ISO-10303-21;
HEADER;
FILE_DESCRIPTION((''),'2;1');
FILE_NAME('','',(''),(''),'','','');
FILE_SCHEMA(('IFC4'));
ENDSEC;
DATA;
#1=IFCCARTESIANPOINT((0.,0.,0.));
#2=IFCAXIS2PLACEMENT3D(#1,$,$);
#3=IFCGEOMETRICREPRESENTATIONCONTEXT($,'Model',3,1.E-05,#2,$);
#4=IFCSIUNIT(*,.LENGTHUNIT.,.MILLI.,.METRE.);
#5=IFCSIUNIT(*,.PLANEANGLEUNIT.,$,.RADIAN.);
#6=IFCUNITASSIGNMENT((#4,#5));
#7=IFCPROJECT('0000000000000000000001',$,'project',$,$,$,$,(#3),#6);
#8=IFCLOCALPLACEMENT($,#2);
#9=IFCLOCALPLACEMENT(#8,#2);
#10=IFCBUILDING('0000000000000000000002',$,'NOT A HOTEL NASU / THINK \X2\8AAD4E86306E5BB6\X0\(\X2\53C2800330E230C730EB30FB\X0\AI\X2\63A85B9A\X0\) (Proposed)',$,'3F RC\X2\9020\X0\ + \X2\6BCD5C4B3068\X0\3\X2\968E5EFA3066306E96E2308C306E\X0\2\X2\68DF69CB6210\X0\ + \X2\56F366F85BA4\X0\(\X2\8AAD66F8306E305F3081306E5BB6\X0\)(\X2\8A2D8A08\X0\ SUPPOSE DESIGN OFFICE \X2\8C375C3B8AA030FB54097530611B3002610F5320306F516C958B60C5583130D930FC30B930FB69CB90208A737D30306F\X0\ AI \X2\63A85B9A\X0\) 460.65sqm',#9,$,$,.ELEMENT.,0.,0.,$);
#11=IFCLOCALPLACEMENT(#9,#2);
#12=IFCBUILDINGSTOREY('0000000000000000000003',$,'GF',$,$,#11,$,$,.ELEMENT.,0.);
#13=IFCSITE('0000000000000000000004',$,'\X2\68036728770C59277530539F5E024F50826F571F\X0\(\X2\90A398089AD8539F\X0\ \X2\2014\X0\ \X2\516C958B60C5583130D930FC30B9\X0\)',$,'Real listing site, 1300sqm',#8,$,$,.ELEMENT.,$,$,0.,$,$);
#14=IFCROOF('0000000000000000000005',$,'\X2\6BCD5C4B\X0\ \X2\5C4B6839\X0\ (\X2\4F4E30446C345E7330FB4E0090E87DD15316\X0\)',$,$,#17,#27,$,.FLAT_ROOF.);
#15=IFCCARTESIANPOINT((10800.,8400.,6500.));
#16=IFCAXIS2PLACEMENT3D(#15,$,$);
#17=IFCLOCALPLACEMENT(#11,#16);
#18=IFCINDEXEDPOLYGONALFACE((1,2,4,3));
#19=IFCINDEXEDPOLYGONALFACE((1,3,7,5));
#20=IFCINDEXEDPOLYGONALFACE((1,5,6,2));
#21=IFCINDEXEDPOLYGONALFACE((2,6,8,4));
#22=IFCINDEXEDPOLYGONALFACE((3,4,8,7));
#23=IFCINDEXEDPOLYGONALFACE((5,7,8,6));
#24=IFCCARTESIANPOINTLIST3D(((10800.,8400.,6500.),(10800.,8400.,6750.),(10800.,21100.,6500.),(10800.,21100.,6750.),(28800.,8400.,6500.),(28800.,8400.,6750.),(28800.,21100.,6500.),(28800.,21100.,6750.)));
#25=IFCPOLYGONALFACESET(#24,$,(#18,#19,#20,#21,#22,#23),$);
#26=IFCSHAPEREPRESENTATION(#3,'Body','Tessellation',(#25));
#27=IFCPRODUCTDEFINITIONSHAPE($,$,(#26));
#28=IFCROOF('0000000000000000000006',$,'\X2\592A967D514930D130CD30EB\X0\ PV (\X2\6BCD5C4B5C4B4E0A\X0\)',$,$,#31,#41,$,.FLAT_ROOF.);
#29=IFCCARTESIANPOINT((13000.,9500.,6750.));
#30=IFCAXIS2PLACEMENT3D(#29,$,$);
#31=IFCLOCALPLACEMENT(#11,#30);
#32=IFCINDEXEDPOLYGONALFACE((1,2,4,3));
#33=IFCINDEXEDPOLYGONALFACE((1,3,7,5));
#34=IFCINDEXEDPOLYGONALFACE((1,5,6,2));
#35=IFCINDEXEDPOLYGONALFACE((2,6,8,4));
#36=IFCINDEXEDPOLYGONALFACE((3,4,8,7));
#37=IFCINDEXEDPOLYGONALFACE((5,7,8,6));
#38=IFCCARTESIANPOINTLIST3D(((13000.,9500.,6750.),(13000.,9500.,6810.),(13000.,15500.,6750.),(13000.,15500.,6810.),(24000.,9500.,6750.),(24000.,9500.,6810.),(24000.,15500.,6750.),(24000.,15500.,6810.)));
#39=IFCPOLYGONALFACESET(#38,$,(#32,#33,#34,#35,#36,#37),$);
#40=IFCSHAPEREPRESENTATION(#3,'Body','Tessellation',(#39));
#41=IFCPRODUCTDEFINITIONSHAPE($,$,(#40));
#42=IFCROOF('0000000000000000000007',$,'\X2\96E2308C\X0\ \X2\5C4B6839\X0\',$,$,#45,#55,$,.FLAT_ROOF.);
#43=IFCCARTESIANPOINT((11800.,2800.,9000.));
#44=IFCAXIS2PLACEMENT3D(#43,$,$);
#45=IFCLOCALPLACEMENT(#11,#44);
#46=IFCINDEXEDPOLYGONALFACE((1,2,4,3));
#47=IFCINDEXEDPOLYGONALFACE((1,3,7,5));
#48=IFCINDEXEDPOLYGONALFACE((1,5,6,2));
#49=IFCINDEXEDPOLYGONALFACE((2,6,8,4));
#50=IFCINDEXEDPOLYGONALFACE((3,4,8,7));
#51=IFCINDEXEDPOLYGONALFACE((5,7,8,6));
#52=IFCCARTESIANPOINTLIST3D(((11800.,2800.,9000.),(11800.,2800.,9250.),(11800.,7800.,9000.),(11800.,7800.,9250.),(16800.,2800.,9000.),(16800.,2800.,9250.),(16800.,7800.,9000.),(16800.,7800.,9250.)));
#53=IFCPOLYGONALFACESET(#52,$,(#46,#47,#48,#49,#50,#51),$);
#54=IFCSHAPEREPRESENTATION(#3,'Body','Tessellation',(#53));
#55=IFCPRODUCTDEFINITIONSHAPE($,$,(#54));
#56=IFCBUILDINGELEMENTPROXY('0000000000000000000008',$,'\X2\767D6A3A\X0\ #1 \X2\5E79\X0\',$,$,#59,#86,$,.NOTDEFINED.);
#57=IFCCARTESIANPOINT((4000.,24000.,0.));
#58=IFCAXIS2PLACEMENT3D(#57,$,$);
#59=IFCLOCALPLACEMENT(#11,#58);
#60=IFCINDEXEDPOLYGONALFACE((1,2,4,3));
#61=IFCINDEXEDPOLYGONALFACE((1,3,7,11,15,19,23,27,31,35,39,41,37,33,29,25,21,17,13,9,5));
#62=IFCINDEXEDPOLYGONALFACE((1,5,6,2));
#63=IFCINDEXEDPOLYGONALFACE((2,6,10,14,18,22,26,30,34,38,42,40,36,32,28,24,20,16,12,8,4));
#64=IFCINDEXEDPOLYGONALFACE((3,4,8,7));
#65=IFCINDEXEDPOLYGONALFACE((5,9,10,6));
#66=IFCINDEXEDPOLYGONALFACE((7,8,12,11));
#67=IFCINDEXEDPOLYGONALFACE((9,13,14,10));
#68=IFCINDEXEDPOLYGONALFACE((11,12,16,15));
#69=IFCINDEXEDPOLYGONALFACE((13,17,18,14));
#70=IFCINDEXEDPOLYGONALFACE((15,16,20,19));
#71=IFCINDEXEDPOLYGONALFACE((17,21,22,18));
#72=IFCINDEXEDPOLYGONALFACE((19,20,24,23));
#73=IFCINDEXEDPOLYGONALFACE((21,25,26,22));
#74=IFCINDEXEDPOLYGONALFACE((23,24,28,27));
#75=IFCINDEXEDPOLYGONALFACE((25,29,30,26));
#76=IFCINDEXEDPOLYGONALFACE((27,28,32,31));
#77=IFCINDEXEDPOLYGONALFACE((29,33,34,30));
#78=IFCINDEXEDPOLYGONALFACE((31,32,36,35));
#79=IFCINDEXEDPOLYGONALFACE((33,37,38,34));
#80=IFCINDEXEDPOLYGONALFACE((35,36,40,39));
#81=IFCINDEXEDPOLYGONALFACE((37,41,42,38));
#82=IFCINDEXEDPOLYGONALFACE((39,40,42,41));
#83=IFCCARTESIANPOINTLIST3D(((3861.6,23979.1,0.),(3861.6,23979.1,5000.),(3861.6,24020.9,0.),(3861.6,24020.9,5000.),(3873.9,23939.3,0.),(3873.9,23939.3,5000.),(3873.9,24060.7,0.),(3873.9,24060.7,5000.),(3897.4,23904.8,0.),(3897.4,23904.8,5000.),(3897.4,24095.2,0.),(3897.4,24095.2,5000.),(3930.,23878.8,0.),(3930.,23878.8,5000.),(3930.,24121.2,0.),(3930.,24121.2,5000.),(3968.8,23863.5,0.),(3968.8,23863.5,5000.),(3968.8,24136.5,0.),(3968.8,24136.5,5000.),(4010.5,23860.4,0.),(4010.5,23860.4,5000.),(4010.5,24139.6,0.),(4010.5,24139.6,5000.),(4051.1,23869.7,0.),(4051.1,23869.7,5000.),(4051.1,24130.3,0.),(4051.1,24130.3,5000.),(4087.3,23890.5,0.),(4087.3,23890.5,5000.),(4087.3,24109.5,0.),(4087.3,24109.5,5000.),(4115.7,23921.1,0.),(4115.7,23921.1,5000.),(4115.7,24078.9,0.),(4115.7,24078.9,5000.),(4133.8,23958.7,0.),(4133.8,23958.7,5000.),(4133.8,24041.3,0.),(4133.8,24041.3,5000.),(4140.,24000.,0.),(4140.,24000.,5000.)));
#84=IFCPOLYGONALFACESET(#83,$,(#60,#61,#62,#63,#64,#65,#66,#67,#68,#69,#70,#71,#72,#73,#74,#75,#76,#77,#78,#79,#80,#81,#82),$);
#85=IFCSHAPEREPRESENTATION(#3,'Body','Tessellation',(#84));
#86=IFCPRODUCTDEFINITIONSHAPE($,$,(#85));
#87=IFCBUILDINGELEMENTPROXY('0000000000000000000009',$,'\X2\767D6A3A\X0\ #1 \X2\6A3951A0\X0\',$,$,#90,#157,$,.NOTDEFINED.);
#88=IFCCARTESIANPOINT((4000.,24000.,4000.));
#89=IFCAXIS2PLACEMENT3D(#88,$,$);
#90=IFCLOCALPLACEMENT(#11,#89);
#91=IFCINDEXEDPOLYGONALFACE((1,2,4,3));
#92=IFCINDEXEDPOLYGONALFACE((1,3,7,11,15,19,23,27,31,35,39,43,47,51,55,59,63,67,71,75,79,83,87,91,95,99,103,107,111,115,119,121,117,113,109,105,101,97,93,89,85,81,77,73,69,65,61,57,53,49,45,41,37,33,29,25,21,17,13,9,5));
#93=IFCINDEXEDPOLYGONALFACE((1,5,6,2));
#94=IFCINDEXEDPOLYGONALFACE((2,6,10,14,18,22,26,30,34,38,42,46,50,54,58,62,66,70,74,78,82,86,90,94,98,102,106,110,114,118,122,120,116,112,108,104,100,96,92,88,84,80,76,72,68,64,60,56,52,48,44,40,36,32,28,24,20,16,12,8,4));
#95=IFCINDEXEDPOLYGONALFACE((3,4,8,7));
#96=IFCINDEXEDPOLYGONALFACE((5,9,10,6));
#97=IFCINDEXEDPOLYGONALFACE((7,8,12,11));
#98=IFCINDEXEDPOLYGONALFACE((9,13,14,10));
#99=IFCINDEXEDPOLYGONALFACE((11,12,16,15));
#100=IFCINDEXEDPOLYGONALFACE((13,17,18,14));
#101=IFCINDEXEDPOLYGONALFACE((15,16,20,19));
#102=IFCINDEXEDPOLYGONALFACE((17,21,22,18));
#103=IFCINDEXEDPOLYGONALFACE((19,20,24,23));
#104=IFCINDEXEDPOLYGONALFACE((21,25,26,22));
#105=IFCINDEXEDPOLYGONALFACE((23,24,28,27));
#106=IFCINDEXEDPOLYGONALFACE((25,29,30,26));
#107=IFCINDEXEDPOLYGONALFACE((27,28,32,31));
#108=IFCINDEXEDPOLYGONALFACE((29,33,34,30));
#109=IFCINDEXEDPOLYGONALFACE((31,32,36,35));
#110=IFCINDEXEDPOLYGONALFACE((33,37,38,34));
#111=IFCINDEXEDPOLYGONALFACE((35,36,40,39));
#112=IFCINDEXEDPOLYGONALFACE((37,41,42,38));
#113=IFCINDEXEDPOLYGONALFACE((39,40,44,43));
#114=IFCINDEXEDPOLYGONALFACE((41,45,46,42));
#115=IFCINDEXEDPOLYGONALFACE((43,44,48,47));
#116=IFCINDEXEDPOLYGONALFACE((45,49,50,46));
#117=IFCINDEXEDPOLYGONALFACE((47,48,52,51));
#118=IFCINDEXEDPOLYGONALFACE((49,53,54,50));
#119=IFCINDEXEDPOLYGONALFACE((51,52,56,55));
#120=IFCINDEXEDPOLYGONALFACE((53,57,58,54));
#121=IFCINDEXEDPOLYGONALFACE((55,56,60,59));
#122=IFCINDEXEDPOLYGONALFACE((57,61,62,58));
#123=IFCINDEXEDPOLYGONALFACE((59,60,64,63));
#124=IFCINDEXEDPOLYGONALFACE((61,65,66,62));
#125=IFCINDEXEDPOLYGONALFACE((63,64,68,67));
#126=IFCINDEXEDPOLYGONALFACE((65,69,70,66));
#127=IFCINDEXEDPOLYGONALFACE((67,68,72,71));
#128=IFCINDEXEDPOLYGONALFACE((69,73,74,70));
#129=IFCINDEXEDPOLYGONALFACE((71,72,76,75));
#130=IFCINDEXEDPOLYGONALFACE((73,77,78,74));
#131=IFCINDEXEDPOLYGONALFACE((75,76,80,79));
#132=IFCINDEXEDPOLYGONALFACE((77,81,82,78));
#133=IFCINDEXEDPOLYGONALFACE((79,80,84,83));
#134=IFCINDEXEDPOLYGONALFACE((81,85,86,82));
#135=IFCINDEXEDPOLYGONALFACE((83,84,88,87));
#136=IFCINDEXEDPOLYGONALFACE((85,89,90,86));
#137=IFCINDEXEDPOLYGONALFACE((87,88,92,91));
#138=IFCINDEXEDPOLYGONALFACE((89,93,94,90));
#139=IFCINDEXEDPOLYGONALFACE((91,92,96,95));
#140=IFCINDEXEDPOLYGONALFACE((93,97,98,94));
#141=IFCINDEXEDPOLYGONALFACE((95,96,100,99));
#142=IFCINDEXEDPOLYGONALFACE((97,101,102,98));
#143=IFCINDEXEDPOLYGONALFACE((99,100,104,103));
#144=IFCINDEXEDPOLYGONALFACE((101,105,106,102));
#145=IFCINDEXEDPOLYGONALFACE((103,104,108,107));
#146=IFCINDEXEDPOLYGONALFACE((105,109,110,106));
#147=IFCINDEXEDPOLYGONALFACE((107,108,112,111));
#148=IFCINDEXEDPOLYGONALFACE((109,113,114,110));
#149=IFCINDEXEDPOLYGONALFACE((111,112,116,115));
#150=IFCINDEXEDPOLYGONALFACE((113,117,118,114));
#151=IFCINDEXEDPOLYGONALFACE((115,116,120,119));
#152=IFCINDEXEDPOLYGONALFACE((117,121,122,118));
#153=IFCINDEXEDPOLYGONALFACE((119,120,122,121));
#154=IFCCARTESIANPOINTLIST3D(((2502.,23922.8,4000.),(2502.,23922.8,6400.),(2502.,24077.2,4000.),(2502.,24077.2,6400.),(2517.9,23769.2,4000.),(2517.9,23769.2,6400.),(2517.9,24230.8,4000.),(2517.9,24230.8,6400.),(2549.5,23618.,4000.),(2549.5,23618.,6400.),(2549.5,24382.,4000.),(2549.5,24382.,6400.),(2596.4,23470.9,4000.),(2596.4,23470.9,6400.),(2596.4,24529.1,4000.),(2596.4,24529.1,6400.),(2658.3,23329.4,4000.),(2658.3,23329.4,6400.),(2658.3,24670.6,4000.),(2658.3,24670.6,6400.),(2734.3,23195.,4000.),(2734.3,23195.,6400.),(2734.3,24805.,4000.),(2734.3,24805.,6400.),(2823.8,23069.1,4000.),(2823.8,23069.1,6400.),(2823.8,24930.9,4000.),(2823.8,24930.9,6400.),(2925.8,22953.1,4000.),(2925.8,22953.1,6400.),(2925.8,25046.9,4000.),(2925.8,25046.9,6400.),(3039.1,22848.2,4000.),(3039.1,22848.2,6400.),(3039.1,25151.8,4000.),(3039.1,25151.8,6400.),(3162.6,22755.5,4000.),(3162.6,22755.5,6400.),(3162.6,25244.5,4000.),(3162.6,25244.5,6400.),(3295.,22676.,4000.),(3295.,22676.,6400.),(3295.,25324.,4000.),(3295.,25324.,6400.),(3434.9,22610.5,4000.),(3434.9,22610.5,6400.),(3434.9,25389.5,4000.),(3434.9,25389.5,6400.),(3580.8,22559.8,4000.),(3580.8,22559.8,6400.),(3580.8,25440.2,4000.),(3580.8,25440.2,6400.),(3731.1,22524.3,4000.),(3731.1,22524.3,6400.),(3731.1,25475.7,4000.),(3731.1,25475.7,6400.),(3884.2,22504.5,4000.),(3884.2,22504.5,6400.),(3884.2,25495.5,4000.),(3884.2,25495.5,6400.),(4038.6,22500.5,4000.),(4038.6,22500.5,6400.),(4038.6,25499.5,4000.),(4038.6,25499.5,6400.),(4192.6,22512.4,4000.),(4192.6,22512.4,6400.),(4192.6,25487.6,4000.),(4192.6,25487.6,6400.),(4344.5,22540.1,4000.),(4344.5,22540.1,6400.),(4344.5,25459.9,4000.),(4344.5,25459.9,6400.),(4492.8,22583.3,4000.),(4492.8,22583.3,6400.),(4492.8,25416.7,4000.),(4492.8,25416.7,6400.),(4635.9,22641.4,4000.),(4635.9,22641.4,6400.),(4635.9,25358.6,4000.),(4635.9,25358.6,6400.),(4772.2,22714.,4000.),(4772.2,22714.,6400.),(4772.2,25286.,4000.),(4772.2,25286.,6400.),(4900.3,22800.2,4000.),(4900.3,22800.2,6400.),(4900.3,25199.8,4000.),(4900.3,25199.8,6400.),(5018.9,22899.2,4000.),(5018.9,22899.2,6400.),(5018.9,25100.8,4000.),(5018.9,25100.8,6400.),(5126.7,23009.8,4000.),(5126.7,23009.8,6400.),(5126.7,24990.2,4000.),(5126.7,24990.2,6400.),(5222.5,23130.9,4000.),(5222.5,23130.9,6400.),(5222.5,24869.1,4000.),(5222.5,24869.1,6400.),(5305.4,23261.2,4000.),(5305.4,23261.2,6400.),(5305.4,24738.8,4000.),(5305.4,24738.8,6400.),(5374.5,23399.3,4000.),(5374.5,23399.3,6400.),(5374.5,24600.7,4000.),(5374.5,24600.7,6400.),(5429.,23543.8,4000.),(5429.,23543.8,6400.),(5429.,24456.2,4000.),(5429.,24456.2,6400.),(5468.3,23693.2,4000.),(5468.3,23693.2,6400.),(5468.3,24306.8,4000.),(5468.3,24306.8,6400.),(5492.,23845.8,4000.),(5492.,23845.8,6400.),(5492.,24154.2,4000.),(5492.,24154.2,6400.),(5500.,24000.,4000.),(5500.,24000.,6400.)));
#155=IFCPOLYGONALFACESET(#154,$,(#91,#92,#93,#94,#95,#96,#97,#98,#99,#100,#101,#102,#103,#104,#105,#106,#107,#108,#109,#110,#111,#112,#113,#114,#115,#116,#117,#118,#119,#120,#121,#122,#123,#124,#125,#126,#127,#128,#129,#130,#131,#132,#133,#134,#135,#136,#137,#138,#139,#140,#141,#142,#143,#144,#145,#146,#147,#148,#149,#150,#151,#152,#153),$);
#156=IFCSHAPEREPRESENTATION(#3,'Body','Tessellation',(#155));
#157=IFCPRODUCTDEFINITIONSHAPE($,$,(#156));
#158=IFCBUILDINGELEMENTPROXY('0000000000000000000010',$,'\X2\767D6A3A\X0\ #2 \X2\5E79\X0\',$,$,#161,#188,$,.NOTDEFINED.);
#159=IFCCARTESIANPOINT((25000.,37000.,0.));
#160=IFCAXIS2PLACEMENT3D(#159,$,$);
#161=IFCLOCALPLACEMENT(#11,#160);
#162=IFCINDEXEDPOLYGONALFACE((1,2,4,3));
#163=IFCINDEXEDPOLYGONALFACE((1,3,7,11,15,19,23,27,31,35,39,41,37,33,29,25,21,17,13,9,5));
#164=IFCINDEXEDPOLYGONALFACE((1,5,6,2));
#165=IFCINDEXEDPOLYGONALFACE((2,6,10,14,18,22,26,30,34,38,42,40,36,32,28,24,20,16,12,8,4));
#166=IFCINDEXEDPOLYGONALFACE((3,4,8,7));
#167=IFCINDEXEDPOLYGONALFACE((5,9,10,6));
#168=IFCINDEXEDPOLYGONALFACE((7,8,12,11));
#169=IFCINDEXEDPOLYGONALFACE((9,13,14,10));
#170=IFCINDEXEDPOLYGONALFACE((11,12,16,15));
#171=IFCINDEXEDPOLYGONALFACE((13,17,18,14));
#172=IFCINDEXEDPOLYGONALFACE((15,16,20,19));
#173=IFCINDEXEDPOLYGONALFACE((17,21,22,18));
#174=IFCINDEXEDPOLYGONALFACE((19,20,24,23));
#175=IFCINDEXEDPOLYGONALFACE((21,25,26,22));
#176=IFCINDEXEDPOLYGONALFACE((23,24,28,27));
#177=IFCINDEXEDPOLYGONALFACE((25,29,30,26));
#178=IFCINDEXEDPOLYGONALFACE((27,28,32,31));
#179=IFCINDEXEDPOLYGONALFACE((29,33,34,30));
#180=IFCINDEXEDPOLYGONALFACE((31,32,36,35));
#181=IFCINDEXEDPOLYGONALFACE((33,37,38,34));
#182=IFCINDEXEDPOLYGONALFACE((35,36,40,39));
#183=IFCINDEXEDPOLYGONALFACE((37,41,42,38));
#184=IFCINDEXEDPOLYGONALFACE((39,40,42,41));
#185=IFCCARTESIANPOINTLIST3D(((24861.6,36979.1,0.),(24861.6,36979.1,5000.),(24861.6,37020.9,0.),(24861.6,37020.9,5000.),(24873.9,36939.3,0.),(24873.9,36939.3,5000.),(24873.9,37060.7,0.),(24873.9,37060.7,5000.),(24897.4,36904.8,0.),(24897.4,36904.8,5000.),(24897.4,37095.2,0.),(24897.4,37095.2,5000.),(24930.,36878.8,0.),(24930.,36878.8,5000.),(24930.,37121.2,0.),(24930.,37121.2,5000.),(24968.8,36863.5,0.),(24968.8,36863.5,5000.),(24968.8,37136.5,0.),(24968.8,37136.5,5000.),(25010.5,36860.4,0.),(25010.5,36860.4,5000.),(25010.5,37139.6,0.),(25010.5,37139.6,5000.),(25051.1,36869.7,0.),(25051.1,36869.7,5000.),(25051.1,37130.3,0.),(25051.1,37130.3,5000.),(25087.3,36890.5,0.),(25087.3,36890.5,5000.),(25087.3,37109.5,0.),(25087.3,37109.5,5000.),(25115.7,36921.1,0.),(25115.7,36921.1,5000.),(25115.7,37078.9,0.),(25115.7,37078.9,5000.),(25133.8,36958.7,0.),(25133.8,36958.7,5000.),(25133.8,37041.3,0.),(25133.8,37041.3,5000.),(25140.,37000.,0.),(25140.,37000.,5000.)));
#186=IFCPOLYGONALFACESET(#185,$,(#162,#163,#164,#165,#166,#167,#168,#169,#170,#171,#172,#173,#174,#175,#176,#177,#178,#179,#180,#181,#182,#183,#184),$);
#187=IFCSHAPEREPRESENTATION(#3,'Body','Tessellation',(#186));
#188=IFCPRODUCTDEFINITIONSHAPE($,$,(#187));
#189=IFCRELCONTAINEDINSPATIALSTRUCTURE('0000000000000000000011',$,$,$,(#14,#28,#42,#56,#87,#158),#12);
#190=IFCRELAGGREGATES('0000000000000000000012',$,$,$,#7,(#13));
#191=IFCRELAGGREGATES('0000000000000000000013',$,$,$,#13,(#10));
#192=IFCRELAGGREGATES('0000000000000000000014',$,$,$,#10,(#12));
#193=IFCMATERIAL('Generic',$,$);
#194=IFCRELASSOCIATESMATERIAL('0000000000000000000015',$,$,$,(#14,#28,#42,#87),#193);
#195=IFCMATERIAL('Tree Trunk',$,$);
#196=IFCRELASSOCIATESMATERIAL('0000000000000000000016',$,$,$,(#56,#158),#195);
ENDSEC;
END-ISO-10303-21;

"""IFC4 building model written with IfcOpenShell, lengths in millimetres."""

from ifc_helpers import new_model, si_unit, frame, frame_2d, origin, origin_2d, place, context, project, spatial, rectangle, circle, extrude, material, element, save


model = new_model("IFC4")

# Units and contexts
model_context = context("Model", 3, precision=1e-05, world=origin())
ifc_project = project(units=[si_unit("LENGTHUNIT", "METRE", prefix="MILLI"), si_unit("PLANEANGLEUNIT", "RADIAN")], contexts=[model_context])

# Site, building, storey
site_placement = place(None, origin())
site = spatial("IfcSite", under=ifc_project, at=site_placement, Name="栃木県大田原市佐良土(那須高原 — 公開情報ベース)", ObjectType="Real listing site, 1300sqm", CompositionType="ELEMENT", RefElevation=0.0)
building_placement = place(site_placement, origin())
building = spatial("IfcBuilding", under=site, at=building_placement, Name="NOT A HOTEL NASU / THINK 読了の家(参考モデル・AI推定) (Proposed)", ObjectType="3F RC造 + 母屋と3階建ての離れの2棟構成 + 図書室(読書のための家)(設計 SUPPOSE DESIGN OFFICE 谷尻誠・吉田愛。意匠は公開情報ベース・構造詳細は AI 推定) 460.65sqm", CompositionType="ELEMENT", ElevationOfRefHeight=0.0, ElevationOfTerrain=0.0)
storey_placement = place(building_placement, origin())
storey = spatial("IfcBuildingStorey", under=building, at=storey_placement, Name="GF", CompositionType="ELEMENT", Elevation=0.0)

# Shared definitions
ifc_material_1 = material(Name="Generic")

# Roofs
roof_1_placement = place(storey_placement, frame((10800.0, 8400.0, 6500.0)))
element("IfcRoof", 1, at=roof_1_placement, inside=storey, material=ifc_material_1, Name="母屋 屋根 (低い水平・一部緑化)", PredefinedType="FLAT_ROOF", context=model_context, shape_type="SweptSolid", body=[
    extrude(rectangle(XDim=18000.0, YDim=12700.0, at=frame_2d((9000.0, 6350.0))), frame((10800.0, 8400.0, 6500.0)), (0.0, 0.0, 1.0), 250.0),
])
roof_2_placement = place(storey_placement, frame((13000.0, 9500.0, 6750.0)))
element("IfcRoof", 2, at=roof_2_placement, inside=storey, material=ifc_material_1, Name="太陽光パネル PV (母屋屋上)", PredefinedType="FLAT_ROOF", context=model_context, shape_type="SweptSolid", body=[
    extrude(rectangle(XDim=11000.0, YDim=6000.0, at=frame_2d((5500.0, 3000.0))), frame((13000.0, 9500.0, 6750.0)), (0.0, 0.0, 1.0), 60.0),
])
roof_3_placement = place(storey_placement, frame((11800.0, 2800.0, 9000.0)))
element("IfcRoof", 3, at=roof_3_placement, inside=storey, material=ifc_material_1, Name="離れ 屋根", PredefinedType="FLAT_ROOF", context=model_context, shape_type="SweptSolid", body=[
    extrude(rectangle(XDim=5000.0, YDim=5000.0, at=frame_2d((2500.0, 2500.0))), frame((11800.0, 2800.0, 9000.0)), (0.0, 0.0, 1.0), 250.0),
])

# Building element proxies
ifc_material_2 = material(Name="Tree Trunk")
proxy_1_placement = place(storey_placement, frame((4000.0, 24000.0, 0.0)))
element("IfcBuildingElementProxy", 4, at=proxy_1_placement, inside=storey, material=ifc_material_2, Name="白樺 #1 幹", PredefinedType="NOTDEFINED", context=model_context, shape_type="SweptSolid", body=[
    extrude(circle(Radius=140.0, at=origin_2d()), frame((4000.0, 24000.0, 0.0)), (0.0, 0.0, 1.0), 5000.0),
])
proxy_2_placement = place(storey_placement, frame((4000.0, 24000.0, 4000.0)))
element("IfcBuildingElementProxy", 5, at=proxy_2_placement, inside=storey, material=ifc_material_1, Name="白樺 #1 樹冠", PredefinedType="NOTDEFINED", context=model_context, shape_type="SweptSolid", body=[
    extrude(circle(Radius=1500.0, at=origin_2d()), frame((4000.0, 24000.0, 4000.0)), (0.0, 0.0, 1.0), 2400.0),
])
proxy_3_placement = place(storey_placement, frame((25000.0, 37000.0, 0.0)))
element("IfcBuildingElementProxy", 6, at=proxy_3_placement, inside=storey, material=ifc_material_2, Name="白樺 #2 幹", PredefinedType="NOTDEFINED", context=model_context, shape_type="SweptSolid", body=[
    extrude(circle(Radius=140.0, at=origin_2d()), frame((25000.0, 37000.0, 0.0)), (0.0, 0.0, 1.0), 5000.0),
])

save(model, "model.ifc")
